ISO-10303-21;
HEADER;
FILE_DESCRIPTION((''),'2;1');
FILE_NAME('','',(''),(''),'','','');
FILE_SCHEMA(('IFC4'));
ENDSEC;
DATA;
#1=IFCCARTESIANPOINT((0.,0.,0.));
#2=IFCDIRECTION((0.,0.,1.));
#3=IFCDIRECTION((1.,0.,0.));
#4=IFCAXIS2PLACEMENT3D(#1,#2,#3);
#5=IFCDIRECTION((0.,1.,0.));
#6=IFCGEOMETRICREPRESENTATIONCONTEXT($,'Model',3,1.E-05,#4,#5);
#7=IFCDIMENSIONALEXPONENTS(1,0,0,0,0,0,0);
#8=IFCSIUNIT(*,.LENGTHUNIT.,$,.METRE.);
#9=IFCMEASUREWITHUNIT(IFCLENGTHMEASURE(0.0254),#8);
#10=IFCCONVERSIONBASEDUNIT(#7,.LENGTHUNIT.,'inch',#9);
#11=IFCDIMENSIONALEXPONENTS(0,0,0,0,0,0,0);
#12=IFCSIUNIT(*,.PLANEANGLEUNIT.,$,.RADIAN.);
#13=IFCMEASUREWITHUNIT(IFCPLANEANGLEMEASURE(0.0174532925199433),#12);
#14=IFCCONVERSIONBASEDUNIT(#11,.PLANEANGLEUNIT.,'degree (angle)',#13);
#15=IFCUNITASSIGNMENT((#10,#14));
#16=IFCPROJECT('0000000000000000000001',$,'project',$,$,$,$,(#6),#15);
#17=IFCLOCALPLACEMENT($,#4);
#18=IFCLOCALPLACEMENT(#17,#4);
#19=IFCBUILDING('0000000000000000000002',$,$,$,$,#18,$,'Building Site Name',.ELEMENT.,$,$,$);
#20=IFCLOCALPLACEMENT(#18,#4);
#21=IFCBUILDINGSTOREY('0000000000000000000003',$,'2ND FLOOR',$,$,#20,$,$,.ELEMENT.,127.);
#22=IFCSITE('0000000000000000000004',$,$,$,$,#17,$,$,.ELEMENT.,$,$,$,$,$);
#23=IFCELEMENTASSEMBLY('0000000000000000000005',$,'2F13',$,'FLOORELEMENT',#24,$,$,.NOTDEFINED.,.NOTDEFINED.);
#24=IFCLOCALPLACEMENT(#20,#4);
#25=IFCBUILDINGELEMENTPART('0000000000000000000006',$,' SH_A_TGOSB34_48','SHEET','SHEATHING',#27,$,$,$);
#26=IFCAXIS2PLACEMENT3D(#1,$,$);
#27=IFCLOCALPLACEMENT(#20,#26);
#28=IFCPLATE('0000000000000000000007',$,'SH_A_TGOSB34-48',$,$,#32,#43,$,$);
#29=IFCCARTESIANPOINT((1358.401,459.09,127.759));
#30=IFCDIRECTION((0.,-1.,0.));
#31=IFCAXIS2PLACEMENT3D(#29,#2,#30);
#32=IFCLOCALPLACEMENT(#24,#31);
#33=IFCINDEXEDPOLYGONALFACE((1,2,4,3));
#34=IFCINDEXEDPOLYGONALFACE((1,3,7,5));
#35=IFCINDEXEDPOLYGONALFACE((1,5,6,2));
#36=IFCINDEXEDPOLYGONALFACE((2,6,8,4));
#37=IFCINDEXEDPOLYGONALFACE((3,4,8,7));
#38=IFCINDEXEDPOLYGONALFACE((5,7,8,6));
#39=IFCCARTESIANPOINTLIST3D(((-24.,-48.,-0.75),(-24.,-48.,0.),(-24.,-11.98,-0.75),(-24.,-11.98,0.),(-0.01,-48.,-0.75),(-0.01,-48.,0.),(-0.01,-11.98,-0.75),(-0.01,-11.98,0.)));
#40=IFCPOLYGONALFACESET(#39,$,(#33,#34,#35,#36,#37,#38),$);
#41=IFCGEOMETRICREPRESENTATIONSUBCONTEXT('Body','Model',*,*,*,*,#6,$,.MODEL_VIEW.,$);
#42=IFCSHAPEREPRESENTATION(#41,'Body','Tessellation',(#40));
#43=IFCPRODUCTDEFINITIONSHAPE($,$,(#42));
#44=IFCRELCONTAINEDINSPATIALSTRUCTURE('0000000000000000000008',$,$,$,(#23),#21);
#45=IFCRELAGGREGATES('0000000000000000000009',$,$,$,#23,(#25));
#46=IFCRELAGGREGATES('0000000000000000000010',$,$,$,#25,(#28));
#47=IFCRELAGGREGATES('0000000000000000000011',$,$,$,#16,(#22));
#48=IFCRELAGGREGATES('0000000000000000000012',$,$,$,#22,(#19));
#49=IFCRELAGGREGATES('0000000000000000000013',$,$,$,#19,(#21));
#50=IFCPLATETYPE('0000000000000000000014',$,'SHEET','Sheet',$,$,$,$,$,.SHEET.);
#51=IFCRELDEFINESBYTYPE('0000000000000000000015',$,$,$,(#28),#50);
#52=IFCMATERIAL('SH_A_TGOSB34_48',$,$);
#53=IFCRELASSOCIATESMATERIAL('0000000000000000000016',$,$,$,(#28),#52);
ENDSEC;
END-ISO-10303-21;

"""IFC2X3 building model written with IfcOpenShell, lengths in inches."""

from ifc_helpers import new_model, entity, si_unit, converted_unit, direction, frame, frame_2d, origin_with_axes, place, context, subcontext, project, spatial, rectangle, extrude, material, type_object, element, aggregate, save


model = new_model("IFC2X3")

# Units and contexts
model_context = context("Model", 3, precision=1e-05, world=origin_with_axes(), true_north=direction((0.0, 1.0, 0.0)))
body_context = subcontext(model_context, "Body", "Model", "MODEL_VIEW")
ifc_project = project(units=[converted_unit("LENGTHUNIT", "inch", entity("IfcLengthMeasure", 0.0254), si_unit("LENGTHUNIT", "METRE"), dimensions=[1, 0, 0, 0, 0, 0, 0]), converted_unit("PLANEANGLEUNIT", "degree (angle)", entity("IfcPlaneAngleMeasure", 0.0174532925199433), si_unit("PLANEANGLEUNIT", "RADIAN"), dimensions=[0, 0, 0, 0, 0, 0, 0])], contexts=[model_context])

# Site, building, storey
site_placement = place(None, origin_with_axes())
site = spatial("IfcSite", under=ifc_project, at=site_placement, CompositionType="ELEMENT")
building_placement = place(site_placement, origin_with_axes())
building = spatial("IfcBuilding", under=site, at=building_placement, LongName="Building Site Name", CompositionType="ELEMENT")
storey_placement = place(building_placement, origin_with_axes())
storey = spatial("IfcBuildingStorey", under=building, at=storey_placement, Name="2ND FLOOR", CompositionType="ELEMENT", Elevation=127.0)

# Element assembly
assembly_1_placement = place(storey_placement, origin_with_axes())
assembly_1 = element("IfcElementAssembly", 1, at=assembly_1_placement, inside=storey, Name="2F13", ObjectType="FLOORELEMENT", AssemblyPlace="NOTDEFINED", PredefinedType="NOTDEFINED")

# Shared definitions
ifc_material_1 = material(Name="SH_A_TGOSB34_48")
plate_type = type_object("IfcPlateType", Name="SHEET", Description="Sheet", PredefinedType="SHEET")

# Building element part
building_element_part_1 = element("IfcBuildingElementPart", 2, Name=" SH_A_TGOSB34_48", Description="SHEET", ObjectType="SHEATHING")
aggregate(assembly_1, [building_element_part_1])

# Plate
plate_1_placement = place(assembly_1_placement, frame((1358.401, 459.09, 127.759), z_axis=(0.0, 0.0, 1.0), x_axis=(0.0, -1.0, 0.0)))
plate_1 = element("IfcPlate", 3, at=plate_1_placement, type_object=plate_type, material=ifc_material_1, Name="SH_A_TGOSB34-48", context=body_context, shape_type="SweptSolid", body=[
    extrude(rectangle(XDim=0.75, YDim=23.99, at=frame_2d((12.005, -0.375), x_axis=(0.0, -1.0))), frame((0.0, -48.0, 0.0), z_axis=(0.0, 1.0, 0.0), x_axis=(-1.0, 0.0, 0.0)), (0.0, 0.0, 1.0), 36.02),
])
aggregate(building_element_part_1, [plate_1])

save(model, "model.ifc")
